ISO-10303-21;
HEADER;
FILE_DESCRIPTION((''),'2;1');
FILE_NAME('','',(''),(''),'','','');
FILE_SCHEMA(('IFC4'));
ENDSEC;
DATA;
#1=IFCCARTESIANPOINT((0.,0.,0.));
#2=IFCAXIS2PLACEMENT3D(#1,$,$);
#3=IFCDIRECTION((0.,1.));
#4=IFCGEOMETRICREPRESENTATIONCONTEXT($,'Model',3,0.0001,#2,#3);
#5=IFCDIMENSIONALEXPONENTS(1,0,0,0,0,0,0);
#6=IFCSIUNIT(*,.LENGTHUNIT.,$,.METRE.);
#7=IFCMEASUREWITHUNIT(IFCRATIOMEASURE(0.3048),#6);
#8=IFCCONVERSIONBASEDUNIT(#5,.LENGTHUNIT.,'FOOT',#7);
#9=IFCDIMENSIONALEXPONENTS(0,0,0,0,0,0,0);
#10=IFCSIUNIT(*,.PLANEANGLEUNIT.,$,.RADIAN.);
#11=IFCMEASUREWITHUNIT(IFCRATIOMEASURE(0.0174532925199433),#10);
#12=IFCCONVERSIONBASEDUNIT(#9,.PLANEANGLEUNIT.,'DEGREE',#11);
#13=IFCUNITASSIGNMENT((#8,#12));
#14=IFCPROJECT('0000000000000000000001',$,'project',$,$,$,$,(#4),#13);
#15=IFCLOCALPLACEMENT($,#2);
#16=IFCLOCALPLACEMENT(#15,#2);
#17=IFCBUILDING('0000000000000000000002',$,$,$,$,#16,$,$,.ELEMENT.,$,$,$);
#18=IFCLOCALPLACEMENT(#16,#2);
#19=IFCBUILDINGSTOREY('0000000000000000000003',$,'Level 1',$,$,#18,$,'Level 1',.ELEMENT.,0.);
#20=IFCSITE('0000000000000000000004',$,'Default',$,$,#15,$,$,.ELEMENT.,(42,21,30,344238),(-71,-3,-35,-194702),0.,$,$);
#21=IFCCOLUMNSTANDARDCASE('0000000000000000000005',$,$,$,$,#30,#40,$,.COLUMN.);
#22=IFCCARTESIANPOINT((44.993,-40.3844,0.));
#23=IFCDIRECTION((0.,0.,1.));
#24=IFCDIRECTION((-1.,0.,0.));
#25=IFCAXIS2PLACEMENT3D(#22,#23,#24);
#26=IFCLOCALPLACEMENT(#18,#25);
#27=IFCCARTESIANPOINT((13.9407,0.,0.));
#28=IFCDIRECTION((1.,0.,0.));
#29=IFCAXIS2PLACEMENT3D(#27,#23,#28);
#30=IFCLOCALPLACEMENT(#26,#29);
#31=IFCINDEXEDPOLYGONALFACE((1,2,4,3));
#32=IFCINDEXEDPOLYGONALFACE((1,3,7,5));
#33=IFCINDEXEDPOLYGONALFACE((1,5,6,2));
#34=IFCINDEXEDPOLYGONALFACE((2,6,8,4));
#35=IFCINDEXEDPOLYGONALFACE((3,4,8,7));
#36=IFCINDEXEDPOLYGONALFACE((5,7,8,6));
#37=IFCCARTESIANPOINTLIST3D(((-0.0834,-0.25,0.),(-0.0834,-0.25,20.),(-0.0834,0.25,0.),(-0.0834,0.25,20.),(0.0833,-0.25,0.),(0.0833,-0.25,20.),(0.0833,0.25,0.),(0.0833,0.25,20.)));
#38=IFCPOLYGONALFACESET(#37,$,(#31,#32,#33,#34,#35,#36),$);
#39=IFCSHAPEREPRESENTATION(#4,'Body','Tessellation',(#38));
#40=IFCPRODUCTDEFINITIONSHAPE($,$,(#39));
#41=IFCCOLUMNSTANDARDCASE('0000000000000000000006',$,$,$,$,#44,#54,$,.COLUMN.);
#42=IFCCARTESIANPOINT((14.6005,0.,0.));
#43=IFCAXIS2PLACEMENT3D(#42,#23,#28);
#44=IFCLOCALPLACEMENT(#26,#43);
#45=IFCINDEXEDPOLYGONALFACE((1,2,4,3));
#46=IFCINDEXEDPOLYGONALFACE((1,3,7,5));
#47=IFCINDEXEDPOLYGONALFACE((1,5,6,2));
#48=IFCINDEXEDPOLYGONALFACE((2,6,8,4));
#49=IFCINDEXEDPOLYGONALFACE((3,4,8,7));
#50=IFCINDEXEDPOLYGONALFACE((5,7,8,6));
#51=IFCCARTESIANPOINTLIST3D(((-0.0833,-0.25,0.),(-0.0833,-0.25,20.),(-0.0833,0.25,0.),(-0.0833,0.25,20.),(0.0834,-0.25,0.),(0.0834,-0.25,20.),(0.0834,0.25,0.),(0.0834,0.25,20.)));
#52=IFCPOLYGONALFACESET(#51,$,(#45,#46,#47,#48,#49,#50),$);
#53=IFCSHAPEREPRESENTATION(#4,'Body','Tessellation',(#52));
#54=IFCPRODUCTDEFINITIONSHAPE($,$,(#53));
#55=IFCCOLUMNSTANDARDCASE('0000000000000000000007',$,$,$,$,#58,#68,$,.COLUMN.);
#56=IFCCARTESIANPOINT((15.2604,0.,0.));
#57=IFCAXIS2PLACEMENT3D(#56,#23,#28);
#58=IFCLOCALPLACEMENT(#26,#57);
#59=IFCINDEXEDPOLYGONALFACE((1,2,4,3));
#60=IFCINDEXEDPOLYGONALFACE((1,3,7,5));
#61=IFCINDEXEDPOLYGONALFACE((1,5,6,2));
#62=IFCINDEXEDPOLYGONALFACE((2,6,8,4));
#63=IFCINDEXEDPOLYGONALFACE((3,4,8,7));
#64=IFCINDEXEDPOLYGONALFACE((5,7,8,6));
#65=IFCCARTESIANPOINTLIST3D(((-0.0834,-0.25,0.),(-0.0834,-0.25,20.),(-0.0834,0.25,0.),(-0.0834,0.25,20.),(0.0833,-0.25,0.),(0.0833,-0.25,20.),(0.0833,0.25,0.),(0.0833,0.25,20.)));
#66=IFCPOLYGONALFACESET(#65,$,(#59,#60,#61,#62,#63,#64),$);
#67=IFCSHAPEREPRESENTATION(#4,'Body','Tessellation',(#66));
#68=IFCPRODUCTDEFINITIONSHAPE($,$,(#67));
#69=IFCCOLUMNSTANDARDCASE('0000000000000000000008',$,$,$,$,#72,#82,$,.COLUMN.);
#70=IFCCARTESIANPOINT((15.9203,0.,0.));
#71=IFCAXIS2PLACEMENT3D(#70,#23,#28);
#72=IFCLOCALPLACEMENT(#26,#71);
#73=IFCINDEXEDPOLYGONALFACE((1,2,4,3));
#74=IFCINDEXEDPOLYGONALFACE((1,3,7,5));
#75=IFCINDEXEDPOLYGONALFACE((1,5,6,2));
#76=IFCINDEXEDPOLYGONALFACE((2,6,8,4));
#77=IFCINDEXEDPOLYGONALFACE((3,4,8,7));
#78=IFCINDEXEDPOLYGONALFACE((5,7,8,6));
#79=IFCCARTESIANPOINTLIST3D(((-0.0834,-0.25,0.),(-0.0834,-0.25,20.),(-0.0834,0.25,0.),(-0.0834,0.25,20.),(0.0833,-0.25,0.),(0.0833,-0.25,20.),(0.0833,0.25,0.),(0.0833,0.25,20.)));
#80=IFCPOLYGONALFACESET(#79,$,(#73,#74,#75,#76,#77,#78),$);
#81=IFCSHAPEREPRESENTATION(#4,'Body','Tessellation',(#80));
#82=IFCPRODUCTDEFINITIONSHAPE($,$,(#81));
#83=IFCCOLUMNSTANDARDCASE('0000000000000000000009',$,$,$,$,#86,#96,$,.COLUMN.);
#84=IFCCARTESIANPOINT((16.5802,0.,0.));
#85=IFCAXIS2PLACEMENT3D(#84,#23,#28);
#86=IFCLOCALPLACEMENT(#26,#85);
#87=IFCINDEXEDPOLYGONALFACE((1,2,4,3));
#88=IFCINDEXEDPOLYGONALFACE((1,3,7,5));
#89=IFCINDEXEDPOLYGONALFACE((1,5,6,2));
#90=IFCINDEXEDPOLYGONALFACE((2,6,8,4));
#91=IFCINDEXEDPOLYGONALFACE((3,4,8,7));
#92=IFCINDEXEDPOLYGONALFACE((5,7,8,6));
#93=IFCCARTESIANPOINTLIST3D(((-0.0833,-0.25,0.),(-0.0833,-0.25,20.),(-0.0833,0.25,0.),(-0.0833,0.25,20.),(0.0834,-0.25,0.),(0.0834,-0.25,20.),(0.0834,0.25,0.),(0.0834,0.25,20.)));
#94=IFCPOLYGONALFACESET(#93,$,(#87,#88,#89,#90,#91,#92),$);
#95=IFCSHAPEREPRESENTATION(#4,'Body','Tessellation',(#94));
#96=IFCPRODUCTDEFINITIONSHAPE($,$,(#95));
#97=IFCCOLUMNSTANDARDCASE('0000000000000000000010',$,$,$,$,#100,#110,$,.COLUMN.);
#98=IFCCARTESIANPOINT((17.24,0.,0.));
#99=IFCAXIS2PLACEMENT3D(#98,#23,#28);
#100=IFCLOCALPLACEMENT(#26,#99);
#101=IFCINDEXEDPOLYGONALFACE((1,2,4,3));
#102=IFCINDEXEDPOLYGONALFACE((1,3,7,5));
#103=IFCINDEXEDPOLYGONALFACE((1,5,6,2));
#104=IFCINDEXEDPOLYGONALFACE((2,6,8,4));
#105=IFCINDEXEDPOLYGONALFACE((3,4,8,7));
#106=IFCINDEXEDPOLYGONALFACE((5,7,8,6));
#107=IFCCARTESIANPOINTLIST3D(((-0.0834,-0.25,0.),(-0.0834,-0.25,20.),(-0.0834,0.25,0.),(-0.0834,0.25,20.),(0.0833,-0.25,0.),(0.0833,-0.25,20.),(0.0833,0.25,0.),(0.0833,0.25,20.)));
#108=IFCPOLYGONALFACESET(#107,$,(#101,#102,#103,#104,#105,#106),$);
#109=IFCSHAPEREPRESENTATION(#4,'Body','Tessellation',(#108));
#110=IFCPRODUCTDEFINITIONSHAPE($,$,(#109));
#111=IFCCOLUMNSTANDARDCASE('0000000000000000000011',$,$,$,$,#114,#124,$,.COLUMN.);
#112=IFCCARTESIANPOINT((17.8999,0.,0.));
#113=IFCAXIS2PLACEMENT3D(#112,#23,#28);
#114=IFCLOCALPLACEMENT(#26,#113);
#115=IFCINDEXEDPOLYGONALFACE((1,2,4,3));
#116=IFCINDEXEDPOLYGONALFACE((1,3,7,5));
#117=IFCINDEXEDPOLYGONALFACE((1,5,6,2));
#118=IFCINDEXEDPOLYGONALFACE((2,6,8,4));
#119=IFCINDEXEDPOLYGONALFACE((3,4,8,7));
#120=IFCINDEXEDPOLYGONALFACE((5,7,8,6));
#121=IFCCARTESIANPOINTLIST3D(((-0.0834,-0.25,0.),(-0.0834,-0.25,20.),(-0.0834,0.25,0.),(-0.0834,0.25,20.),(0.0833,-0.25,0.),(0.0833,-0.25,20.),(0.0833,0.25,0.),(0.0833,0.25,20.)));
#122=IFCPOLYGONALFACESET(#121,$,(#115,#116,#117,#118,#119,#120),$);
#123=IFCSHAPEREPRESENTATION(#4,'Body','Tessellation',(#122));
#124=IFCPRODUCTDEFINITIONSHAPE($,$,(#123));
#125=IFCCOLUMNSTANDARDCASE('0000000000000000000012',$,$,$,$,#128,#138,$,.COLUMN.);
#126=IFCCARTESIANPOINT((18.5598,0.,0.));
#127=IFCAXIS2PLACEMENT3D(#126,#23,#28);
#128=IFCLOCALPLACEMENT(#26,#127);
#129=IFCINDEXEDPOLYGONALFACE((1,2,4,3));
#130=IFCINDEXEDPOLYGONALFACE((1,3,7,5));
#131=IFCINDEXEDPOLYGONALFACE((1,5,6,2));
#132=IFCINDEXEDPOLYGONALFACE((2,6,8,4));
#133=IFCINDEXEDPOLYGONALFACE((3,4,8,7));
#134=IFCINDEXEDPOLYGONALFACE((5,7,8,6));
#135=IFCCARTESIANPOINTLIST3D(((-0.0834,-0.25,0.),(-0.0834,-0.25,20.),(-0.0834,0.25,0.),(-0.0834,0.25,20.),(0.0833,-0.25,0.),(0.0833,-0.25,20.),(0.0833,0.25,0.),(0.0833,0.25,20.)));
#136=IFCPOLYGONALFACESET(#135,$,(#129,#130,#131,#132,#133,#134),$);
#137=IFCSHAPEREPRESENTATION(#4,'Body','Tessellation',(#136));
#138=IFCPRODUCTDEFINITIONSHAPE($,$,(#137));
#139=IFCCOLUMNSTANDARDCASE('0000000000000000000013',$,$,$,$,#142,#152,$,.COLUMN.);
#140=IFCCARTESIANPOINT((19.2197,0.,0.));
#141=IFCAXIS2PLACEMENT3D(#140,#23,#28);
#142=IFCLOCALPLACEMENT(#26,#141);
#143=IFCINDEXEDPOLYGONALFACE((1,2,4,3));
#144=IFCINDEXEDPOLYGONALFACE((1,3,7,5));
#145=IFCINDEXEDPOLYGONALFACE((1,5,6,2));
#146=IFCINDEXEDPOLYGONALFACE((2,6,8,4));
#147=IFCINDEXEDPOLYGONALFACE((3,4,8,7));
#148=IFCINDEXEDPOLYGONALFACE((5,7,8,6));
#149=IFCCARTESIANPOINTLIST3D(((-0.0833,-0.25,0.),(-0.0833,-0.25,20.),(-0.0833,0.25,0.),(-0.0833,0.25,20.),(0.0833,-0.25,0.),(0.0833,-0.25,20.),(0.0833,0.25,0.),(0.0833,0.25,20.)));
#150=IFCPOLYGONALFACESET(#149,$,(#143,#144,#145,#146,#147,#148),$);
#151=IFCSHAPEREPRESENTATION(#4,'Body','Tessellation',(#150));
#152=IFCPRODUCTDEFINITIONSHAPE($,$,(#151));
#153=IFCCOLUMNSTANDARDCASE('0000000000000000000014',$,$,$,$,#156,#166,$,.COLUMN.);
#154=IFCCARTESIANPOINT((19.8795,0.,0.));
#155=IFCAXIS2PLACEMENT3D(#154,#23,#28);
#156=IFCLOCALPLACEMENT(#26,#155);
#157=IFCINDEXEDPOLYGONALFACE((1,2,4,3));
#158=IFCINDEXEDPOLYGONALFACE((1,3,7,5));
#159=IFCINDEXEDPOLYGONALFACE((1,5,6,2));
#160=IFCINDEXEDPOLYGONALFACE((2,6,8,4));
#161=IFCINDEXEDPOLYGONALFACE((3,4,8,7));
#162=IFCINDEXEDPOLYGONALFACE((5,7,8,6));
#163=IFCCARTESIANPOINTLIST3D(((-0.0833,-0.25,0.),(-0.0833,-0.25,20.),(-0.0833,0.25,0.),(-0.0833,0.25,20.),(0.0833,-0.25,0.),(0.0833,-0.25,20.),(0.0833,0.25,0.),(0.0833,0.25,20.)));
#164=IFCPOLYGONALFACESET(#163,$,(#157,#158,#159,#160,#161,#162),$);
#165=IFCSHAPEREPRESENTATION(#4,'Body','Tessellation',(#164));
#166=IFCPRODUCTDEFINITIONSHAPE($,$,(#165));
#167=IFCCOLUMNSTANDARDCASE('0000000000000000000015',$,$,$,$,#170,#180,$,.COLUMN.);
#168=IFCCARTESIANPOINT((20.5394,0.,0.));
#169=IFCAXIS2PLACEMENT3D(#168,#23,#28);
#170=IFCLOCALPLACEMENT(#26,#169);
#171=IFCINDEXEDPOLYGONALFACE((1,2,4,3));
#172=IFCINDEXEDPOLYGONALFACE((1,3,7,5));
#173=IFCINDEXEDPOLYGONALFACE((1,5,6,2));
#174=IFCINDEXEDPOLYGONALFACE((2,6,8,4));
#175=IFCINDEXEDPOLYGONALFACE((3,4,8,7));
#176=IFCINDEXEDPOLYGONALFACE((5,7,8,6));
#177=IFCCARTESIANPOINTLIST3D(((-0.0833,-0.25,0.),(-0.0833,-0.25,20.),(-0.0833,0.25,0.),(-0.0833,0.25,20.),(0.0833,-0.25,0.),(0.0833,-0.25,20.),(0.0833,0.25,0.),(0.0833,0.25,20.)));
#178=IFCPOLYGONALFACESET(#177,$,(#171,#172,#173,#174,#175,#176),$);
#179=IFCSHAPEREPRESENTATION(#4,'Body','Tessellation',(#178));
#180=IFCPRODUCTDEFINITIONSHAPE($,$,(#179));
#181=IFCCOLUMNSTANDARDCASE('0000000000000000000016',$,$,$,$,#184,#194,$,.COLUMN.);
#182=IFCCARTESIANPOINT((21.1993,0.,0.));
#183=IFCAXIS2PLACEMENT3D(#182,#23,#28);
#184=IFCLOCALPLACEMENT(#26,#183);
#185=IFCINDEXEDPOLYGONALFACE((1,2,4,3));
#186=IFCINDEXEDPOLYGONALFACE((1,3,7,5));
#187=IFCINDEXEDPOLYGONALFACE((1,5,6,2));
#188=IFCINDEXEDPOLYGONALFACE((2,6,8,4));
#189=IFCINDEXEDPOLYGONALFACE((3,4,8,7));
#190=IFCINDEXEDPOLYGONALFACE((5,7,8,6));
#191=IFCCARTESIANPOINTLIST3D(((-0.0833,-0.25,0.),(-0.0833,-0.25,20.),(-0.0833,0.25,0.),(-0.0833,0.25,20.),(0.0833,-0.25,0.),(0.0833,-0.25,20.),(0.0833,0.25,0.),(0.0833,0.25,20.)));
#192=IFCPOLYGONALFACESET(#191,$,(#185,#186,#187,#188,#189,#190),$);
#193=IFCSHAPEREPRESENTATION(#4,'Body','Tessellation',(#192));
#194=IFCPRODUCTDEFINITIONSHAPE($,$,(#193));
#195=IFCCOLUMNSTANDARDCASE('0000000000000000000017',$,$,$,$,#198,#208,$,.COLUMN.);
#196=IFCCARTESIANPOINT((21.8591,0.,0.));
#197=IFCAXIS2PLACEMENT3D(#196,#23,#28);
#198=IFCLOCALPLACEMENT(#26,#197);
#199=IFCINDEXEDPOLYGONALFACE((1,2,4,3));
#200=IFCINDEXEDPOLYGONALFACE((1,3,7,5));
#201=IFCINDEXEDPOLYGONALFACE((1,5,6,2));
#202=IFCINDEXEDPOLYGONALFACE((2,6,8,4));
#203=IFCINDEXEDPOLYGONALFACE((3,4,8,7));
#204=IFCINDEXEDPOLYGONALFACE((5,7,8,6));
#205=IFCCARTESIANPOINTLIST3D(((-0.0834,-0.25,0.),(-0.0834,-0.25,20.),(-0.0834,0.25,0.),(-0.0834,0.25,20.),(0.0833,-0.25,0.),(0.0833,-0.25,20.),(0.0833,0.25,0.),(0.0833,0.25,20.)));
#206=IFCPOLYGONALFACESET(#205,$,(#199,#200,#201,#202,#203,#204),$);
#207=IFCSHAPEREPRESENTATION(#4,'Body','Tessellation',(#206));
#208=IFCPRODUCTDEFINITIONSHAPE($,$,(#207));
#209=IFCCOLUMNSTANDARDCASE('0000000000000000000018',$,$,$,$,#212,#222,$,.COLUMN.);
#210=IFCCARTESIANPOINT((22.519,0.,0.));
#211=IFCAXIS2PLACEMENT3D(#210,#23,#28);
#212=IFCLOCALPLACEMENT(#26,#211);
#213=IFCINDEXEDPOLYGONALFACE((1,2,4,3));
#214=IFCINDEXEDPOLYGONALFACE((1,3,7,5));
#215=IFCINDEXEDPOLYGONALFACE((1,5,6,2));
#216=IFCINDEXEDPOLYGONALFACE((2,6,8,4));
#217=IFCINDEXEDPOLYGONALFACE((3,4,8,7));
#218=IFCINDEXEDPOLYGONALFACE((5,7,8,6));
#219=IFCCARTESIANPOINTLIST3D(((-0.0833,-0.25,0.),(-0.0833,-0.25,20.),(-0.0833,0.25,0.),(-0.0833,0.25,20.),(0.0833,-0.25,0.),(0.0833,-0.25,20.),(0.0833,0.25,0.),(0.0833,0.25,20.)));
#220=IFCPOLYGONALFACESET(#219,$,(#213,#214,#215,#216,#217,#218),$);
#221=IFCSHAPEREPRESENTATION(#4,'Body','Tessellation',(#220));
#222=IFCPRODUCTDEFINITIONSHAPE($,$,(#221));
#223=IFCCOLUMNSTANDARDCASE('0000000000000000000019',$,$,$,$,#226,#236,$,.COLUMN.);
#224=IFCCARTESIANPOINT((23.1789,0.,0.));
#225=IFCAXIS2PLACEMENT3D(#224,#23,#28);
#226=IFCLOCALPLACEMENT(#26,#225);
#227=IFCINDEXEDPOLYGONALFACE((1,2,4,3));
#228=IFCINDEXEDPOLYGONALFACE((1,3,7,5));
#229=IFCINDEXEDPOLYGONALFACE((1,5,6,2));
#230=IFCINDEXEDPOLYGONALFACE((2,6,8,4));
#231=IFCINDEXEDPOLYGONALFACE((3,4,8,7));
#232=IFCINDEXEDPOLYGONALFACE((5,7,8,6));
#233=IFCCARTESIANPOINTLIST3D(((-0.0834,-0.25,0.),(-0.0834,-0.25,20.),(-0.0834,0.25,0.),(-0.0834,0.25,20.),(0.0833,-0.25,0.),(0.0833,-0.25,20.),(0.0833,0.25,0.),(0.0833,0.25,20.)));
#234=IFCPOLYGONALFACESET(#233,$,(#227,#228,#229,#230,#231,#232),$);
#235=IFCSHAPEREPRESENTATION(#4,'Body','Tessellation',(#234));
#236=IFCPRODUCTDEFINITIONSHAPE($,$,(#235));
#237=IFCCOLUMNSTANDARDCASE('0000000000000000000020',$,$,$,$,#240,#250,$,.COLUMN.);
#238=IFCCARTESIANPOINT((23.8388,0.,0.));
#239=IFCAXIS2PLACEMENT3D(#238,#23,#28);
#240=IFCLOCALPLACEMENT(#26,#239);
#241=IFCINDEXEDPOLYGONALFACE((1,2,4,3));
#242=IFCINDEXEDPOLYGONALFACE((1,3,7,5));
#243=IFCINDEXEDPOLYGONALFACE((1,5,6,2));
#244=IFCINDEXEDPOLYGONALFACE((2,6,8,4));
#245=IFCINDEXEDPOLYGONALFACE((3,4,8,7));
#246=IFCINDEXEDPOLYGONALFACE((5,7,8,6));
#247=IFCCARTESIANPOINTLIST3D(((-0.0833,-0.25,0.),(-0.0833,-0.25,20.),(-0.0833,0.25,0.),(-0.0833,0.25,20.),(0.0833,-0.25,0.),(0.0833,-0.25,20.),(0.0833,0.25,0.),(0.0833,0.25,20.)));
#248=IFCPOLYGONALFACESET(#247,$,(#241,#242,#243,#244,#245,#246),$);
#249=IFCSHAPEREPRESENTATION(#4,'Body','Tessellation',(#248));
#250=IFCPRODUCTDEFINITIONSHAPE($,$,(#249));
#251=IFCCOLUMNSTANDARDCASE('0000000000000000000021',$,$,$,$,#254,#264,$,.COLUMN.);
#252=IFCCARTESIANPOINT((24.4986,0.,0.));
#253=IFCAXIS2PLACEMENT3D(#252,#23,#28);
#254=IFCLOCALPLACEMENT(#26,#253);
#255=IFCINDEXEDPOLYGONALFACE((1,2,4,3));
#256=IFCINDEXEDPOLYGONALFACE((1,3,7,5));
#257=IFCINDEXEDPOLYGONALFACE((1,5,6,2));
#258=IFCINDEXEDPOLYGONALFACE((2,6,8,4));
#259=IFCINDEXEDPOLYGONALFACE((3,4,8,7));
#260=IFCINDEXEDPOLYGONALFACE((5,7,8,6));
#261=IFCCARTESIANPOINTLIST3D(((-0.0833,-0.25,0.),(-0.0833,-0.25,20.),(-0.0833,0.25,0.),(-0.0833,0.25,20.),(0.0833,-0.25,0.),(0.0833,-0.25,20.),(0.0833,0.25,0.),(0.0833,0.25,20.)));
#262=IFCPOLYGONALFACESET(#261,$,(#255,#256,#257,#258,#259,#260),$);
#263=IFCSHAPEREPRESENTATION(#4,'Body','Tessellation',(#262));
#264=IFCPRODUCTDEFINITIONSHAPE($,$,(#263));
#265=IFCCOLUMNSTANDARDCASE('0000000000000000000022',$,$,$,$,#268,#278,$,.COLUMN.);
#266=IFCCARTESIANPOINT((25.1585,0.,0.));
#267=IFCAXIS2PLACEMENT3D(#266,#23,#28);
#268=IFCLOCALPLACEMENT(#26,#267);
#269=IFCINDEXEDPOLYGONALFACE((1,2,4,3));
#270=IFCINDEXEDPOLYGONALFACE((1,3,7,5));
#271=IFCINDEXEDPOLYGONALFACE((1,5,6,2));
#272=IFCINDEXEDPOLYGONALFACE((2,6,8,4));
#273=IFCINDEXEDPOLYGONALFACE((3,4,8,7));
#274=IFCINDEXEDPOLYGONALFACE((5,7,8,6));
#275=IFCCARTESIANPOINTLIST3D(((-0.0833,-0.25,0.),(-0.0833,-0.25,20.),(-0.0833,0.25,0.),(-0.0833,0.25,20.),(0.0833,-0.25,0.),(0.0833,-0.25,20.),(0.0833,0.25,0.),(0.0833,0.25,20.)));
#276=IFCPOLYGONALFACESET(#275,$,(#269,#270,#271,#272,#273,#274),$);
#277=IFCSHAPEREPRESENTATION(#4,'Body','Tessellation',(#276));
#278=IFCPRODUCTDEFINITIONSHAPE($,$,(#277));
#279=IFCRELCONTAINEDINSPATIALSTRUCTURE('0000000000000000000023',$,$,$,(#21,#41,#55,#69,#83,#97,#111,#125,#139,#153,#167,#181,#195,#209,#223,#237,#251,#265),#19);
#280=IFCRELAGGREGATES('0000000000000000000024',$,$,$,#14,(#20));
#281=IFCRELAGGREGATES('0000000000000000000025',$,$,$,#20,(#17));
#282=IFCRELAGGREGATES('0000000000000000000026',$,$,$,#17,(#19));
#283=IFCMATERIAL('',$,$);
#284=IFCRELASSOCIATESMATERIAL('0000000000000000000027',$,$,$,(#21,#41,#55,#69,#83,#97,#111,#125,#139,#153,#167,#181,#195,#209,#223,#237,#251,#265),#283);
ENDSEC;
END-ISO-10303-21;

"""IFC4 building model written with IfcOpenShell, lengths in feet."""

from ifc_helpers import new_model, entity, si_unit, converted_unit, direction, frame, origin, place, context, project, spatial, rectangle, extrude, material, element, save


model = new_model("IFC4")

# Units and contexts
model_context = context("Model", 3, precision=0.0001, world=origin(), true_north=direction((0.0, 1.0)))
ifc_project = project(units=[converted_unit("LENGTHUNIT", "FOOT", entity("IfcRatioMeasure", 0.3048), si_unit("LENGTHUNIT", "METRE"), dimensions=[1, 0, 0, 0, 0, 0, 0]), converted_unit("PLANEANGLEUNIT", "DEGREE", entity("IfcRatioMeasure", 0.0174532925199433), si_unit("PLANEANGLEUNIT", "RADIAN"), dimensions=[0, 0, 0, 0, 0, 0, 0])], contexts=[model_context])

# Site, building, storey
site_placement = place(None, origin())
site = spatial("IfcSite", under=ifc_project, at=site_placement, Name="Default", CompositionType="ELEMENT", RefLatitude=(42, 21, 30, 344238), RefLongitude=(-71, -3, -35, -194702), RefElevation=0.0)
building_placement = place(site_placement, origin())
building = spatial("IfcBuilding", under=site, at=building_placement, CompositionType="ELEMENT")
storey_placement = place(building_placement, origin())
storey = spatial("IfcBuildingStorey", under=building, at=storey_placement, Name="Level 1", LongName="Level 1", CompositionType="ELEMENT", Elevation=0.0)

# Columns
ifc_material = material(Name="")
placement = place(storey_placement, frame((44.993, -40.3844, 0.0), z_axis=(0.0, 0.0, 1.0), x_axis=(-1.0, 0.0, 0.0)))
for number, where, z_axis, x_axis in (
    (1, (13.9407, 0.0, 0.0), (0.0, 0.0, 1.0), (1.0, 0.0, 0.0)),
    (2, (14.6005, 0.0, 0.0), (0.0, 0.0, 1.0), (1.0, 0.0, 0.0)),
    (3, (15.2604, 0.0, 0.0), (0.0, 0.0, 1.0), (1.0, 0.0, 0.0)),
    (4, (15.9203, 0.0, 0.0), (0.0, 0.0, 1.0), (1.0, 0.0, 0.0)),
    (5, (16.5802, 0.0, 0.0), (0.0, 0.0, 1.0), (1.0, 0.0, 0.0)),
    (6, (17.24, 0.0, 0.0), (0.0, 0.0, 1.0), (1.0, 0.0, 0.0)),
    (7, (17.8999, 0.0, 0.0), (0.0, 0.0, 1.0), (1.0, 0.0, 0.0)),
    (8, (18.5598, 0.0, 0.0), (0.0, 0.0, 1.0), (1.0, 0.0, 0.0)),
    (9, (19.2197, 0.0, 0.0), (0.0, 0.0, 1.0), (1.0, 0.0, 0.0)),
    (10, (19.8795, 0.0, 0.0), (0.0, 0.0, 1.0), (1.0, 0.0, 0.0)),
    (11, (20.5394, 0.0, 0.0), (0.0, 0.0, 1.0), (1.0, 0.0, 0.0)),
    (12, (21.1993, 0.0, 0.0), (0.0, 0.0, 1.0), (1.0, 0.0, 0.0)),
    (13, (21.8591, 0.0, 0.0), (0.0, 0.0, 1.0), (1.0, 0.0, 0.0)),
    (14, (22.519, 0.0, 0.0), (0.0, 0.0, 1.0), (1.0, 0.0, 0.0)),
    (15, (23.1789, 0.0, 0.0), (0.0, 0.0, 1.0), (1.0, 0.0, 0.0)),
    (16, (23.8388, 0.0, 0.0), (0.0, 0.0, 1.0), (1.0, 0.0, 0.0)),
    (17, (24.4986, 0.0, 0.0), (0.0, 0.0, 1.0), (1.0, 0.0, 0.0)),
    (18, (25.1585, 0.0, 0.0), (0.0, 0.0, 1.0), (1.0, 0.0, 0.0)),
):
    element("IfcColumnStandardCase", number, at=place(placement, frame(where, z_axis=z_axis, x_axis=x_axis)), inside=storey, material=ifc_material, PredefinedType="COLUMN", context=model_context, shape_type="SweptSolid", body=[
        extrude(rectangle(XDim=0.1667, YDim=0.5), origin(), (0.0, 0.0, 1.0), 20.0),
    ])

save(model, "model.ifc")
